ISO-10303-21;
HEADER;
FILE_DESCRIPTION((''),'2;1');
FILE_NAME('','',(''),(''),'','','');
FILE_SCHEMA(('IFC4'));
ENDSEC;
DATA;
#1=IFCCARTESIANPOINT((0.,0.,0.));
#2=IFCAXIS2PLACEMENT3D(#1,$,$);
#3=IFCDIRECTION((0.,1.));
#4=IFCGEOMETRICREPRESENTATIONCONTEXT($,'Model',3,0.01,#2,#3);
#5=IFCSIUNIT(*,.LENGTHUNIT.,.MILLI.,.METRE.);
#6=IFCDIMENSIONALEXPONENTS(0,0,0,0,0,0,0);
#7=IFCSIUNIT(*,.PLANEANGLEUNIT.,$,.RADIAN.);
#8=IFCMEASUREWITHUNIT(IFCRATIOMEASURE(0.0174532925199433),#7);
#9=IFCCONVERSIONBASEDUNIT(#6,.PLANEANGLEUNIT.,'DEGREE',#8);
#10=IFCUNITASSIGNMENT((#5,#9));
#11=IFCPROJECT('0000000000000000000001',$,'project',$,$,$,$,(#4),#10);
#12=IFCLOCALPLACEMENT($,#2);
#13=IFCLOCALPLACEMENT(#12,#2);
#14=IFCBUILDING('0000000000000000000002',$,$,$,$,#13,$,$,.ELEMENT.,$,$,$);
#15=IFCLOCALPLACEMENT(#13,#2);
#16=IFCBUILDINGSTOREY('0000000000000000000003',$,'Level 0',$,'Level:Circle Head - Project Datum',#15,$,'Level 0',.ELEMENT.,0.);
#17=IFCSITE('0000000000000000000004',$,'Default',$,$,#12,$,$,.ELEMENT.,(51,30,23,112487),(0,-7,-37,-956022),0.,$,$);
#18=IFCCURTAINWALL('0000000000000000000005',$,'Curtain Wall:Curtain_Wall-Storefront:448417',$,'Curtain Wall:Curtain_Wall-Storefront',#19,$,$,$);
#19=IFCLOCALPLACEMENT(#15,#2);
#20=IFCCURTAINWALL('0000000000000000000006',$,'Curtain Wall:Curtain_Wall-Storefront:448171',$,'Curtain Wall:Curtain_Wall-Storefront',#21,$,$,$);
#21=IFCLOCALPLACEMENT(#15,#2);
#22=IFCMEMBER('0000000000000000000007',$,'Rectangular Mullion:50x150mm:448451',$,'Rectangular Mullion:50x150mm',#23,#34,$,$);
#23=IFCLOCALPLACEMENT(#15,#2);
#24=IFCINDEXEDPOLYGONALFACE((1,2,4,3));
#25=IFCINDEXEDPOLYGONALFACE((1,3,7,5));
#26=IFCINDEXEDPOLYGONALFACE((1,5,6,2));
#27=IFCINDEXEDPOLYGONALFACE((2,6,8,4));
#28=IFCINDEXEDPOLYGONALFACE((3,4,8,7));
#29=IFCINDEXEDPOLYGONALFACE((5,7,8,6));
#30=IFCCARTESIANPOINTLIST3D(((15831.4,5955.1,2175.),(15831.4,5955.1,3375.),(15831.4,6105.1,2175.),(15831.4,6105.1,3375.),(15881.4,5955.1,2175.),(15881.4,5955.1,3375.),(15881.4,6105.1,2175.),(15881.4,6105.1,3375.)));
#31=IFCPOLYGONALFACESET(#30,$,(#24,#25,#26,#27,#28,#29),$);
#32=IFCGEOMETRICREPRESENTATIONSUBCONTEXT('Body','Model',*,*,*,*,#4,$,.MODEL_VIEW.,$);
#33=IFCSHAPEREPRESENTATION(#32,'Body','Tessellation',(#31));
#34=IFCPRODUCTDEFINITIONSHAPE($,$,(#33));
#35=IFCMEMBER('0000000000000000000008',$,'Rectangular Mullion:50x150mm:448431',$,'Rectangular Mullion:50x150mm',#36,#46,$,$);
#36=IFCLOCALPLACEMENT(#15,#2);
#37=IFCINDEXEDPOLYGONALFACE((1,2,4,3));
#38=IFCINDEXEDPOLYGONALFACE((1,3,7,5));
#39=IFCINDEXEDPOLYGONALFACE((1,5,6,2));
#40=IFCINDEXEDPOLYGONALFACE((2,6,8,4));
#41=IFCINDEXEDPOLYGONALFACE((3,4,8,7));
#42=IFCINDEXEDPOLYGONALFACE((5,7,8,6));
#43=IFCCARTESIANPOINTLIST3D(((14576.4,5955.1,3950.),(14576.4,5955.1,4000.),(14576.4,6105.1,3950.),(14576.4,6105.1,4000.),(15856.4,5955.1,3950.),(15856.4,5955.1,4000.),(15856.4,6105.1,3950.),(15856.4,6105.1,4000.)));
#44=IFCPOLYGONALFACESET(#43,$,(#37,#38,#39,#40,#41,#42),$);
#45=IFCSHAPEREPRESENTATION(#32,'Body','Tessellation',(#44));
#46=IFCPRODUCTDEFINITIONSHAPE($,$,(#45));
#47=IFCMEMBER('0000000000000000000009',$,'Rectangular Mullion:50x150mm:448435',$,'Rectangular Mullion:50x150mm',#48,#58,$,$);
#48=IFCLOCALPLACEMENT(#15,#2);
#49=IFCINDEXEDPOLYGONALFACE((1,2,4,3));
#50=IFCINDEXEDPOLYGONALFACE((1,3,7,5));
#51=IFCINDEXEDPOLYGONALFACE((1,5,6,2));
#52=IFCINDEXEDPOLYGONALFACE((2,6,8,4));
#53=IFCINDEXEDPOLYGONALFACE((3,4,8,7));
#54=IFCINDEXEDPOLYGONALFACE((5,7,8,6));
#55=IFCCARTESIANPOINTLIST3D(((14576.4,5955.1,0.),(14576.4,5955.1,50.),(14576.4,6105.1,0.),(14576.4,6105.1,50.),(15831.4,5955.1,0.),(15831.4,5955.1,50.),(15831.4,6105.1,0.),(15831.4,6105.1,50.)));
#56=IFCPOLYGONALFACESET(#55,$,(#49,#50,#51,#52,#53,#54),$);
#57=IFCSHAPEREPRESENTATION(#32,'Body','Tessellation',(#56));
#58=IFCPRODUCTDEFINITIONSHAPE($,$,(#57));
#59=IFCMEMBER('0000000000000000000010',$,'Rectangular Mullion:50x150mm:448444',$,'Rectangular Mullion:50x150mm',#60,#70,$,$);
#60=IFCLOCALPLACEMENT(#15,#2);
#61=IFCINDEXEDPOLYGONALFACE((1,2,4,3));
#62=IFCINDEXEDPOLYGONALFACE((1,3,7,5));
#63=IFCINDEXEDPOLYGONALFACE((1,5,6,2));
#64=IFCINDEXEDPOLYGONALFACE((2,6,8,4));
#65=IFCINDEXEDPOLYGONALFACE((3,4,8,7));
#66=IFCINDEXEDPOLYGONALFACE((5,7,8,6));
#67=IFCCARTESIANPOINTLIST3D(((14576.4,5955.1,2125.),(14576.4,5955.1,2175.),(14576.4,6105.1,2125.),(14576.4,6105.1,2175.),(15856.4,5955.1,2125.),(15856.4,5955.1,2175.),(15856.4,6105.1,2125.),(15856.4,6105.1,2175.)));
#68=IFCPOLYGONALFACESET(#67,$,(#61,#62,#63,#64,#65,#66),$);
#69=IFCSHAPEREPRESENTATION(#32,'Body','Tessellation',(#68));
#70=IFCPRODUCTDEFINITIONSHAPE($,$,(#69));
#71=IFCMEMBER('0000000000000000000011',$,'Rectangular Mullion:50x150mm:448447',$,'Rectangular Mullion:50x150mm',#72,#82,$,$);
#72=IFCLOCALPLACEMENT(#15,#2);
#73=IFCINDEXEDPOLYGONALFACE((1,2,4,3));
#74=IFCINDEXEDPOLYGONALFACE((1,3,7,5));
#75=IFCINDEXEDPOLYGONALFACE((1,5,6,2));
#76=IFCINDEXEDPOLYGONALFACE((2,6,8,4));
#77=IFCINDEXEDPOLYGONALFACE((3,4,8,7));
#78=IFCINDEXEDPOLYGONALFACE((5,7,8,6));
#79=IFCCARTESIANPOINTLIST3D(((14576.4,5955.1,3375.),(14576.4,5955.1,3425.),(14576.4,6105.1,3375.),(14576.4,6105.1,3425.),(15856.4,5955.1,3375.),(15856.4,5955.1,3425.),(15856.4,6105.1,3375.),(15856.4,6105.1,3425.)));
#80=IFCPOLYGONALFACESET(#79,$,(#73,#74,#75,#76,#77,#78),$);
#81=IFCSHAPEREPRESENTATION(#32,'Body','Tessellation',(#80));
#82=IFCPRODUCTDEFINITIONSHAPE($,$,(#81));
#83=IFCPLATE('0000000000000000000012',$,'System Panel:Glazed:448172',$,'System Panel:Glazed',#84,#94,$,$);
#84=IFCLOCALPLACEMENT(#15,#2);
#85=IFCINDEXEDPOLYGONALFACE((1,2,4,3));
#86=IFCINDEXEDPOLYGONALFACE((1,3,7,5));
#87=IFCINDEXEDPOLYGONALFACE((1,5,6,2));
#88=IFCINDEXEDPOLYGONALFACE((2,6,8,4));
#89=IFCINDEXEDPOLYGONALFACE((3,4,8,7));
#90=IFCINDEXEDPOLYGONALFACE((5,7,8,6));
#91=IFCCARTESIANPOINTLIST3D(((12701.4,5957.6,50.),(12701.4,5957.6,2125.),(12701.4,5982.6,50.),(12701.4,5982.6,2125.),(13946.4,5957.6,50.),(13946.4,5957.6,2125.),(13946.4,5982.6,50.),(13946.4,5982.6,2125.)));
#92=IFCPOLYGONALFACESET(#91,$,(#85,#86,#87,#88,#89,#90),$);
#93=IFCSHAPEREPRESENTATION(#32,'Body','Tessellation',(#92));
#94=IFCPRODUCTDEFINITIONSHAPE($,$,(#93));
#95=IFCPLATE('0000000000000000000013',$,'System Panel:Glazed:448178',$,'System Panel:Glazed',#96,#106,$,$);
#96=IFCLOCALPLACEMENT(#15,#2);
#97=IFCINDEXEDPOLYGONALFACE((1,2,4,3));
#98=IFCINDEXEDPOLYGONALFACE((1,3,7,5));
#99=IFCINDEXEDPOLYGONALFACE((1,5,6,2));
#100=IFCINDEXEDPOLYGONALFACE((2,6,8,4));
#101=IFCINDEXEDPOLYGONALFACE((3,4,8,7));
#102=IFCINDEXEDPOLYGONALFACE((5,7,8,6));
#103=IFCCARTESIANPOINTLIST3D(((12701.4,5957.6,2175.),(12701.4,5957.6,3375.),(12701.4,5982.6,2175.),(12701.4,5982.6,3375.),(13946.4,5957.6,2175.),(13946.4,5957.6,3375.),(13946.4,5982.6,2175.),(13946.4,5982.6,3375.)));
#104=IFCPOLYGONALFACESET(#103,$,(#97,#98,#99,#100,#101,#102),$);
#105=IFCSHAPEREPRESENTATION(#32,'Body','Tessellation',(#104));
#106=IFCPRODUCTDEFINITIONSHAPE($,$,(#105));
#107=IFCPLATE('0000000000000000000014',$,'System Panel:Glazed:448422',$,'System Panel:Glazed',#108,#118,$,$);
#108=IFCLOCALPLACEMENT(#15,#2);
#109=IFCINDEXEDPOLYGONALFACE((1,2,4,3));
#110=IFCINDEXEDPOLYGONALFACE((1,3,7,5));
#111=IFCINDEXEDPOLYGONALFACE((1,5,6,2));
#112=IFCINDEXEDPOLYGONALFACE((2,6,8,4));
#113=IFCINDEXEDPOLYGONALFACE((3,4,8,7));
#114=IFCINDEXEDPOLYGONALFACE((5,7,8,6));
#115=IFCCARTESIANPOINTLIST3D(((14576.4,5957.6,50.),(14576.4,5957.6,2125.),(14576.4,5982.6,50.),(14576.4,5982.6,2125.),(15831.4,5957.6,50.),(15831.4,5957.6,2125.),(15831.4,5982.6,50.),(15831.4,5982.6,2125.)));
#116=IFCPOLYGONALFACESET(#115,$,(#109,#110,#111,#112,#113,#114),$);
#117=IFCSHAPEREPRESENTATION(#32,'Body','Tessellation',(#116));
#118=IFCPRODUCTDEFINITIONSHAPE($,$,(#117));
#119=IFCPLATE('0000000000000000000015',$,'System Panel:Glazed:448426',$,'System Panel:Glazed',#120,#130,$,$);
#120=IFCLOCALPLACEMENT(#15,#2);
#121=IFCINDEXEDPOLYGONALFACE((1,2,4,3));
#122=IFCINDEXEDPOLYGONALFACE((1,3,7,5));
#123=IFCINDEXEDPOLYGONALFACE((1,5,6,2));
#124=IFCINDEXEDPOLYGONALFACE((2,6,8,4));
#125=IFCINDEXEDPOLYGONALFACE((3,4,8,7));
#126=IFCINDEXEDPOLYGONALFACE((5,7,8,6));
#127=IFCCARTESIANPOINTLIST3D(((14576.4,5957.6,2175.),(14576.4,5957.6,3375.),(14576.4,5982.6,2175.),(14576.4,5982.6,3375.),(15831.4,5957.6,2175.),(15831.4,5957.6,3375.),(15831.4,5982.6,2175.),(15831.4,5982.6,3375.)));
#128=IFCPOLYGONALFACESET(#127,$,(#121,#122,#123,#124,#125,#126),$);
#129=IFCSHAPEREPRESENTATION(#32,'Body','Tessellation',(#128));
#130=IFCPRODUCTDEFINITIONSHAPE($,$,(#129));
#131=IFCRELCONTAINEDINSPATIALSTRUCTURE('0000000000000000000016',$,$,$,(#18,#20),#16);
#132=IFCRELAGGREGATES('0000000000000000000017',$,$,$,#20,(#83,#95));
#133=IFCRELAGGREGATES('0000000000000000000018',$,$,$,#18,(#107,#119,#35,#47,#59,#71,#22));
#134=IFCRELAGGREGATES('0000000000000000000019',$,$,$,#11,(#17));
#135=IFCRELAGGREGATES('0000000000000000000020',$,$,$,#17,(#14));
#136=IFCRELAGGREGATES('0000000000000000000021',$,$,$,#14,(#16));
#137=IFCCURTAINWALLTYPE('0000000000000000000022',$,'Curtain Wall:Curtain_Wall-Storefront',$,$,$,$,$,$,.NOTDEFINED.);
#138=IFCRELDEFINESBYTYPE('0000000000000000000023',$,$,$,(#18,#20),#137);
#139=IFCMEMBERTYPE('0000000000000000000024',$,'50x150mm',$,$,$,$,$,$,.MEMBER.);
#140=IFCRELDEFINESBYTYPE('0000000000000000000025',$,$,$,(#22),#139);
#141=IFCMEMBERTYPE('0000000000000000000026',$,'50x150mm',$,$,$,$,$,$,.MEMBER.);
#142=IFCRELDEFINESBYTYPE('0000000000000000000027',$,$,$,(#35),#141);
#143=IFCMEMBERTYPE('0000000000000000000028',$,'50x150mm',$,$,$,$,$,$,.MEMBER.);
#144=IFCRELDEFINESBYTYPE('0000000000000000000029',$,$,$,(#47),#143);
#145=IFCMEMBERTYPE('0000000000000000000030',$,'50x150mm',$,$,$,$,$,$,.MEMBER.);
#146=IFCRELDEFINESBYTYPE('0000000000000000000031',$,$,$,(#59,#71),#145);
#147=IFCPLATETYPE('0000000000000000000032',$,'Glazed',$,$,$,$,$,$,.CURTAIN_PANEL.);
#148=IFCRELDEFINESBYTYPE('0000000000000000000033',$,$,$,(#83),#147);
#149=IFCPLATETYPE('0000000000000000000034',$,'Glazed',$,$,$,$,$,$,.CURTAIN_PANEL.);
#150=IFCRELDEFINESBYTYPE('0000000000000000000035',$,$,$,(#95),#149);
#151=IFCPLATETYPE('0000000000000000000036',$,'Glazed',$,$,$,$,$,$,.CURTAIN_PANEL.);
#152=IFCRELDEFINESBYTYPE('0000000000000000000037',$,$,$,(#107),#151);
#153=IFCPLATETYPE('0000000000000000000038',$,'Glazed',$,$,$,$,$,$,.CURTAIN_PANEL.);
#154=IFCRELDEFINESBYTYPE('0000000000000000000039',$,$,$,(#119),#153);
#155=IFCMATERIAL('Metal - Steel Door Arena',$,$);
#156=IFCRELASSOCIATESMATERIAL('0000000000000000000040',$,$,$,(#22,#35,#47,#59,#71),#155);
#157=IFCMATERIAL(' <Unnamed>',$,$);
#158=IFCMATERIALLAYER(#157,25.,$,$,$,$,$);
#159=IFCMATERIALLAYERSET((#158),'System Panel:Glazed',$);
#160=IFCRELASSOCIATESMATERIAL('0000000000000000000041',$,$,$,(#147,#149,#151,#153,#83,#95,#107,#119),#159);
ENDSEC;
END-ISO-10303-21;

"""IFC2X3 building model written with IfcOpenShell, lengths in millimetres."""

from ifc_helpers import new_model, entity, si_unit, converted_unit, direction, frame, origin, origin_2d_with_axis, place, context, subcontext, project, spatial, rectangle, extrude, source, transform, mapped, material, layer, layer_set, layer_usage, type_object, type_shapes, element, aggregate, save


model = new_model("IFC2X3")

# Units and contexts
model_context = context("Model", 3, precision=0.01, world=origin(), true_north=direction((0.0, 1.0)))
body_context = subcontext(model_context, "Body", "Model", "MODEL_VIEW")
ifc_project = project(units=[si_unit("LENGTHUNIT", "METRE", prefix="MILLI"), converted_unit("PLANEANGLEUNIT", "DEGREE", entity("IfcRatioMeasure", 0.0174532925199433), si_unit("PLANEANGLEUNIT", "RADIAN"), dimensions=[0, 0, 0, 0, 0, 0, 0])], contexts=[model_context])

# Site, building, storey
site_placement = place(None, origin())
site = spatial("IfcSite", under=ifc_project, at=site_placement, Name="Default", CompositionType="ELEMENT", RefLatitude=(51, 30, 23, 112487), RefLongitude=(0, -7, -37, -956022), RefElevation=0.0)
building_placement = place(site_placement, origin())
building = spatial("IfcBuilding", under=site, at=building_placement, CompositionType="ELEMENT")
storey_placement = place(building_placement, origin())
storey = spatial("IfcBuildingStorey", under=building, at=storey_placement, Name="Level 0", ObjectType="Level:Circle Head - Project Datum", LongName="Level 0", CompositionType="ELEMENT", Elevation=0.0)

# Curtain walls
curtain_wall_type = type_object("IfcCurtainWallType", Name="Curtain Wall:Curtain_Wall-Storefront", PredefinedType="NOTDEFINED")
curtain_wall_1_placement = place(storey_placement, origin())
curtain_wall_1 = element("IfcCurtainWall", 1, at=curtain_wall_1_placement, inside=storey, type_object=curtain_wall_type, Name="Curtain Wall:Curtain_Wall-Storefront:448417", ObjectType="Curtain Wall:Curtain_Wall-Storefront")
ifc_material_1 = material(Name="Metal - Steel Door Arena")
curtain_wall_2_placement = place(storey_placement, origin())
curtain_wall_2 = element("IfcCurtainWall", 2, at=curtain_wall_2_placement, inside=storey, type_object=curtain_wall_type, Name="Curtain Wall:Curtain_Wall-Storefront:448171", ObjectType="Curtain Wall:Curtain_Wall-Storefront")

# Members
member_type_1 = type_object("IfcMemberType", Name="50x150mm", PredefinedType="MEMBER")
shared_shape_1 = source(origin(), body_context, "Body", "SweptSolid", [
    extrude(rectangle(XDim=150.0, YDim=50.0, at=origin_2d_with_axis()), frame((0.0, 0.0, -1200.0), z_axis=(0.0, 0.0, 1.0), x_axis=(0.0, -1.0, 0.0)), (0.0, 0.0, 1.0), 1200.0),
])
type_shapes(member_type_1, [shared_shape_1])
member_1_placement = place(storey_placement, frame((15856.4, 6030.1, 2175.0), z_axis=(0.0, 0.0, -1.0), x_axis=(-1.0, 0.0, 0.0)))
member_1 = element("IfcMember", 3, at=member_1_placement, type_object=member_type_1, material=ifc_material_1, Name="Rectangular Mullion:50x150mm:448451", ObjectType="Rectangular Mullion:50x150mm", context=body_context, shape_type="MappedRepresentation", body=[
    mapped(shared_shape_1, transform((0.0, 0.0, 0.0), scale=1.0)),
])
member_type_2 = type_object("IfcMemberType", Name="50x150mm", PredefinedType="MEMBER")
shared_shape_2 = source(origin(), body_context, "Body", "SweptSolid", [
    extrude(rectangle(XDim=150.0, YDim=50.0, at=origin_2d_with_axis()), frame((-25.0, 0.0, -1280.0), z_axis=(0.0, 0.0, 1.0), x_axis=(0.0, -1.0, 0.0)), (0.0, 0.0, 1.0), 1280.0),
])
type_shapes(member_type_2, [shared_shape_2])
member_2_placement = place(storey_placement, frame((14576.4, 6030.1, 4000.0), z_axis=(-1.0, 0.0, 0.0), x_axis=(0.0, 0.0, 1.0)))
member_2 = element("IfcMember", 4, at=member_2_placement, type_object=member_type_2, material=ifc_material_1, Name="Rectangular Mullion:50x150mm:448431", ObjectType="Rectangular Mullion:50x150mm", context=body_context, shape_type="MappedRepresentation", body=[
    mapped(shared_shape_2, transform((0.0, 0.0, 0.0), scale=1.0)),
])
member_type_3 = type_object("IfcMemberType", Name="50x150mm", PredefinedType="MEMBER")
shared_shape_3 = source(origin(), body_context, "Body", "SweptSolid", [
    extrude(rectangle(XDim=150.0, YDim=50.0, at=origin_2d_with_axis()), frame((-25.0, 0.0, -1255.0), z_axis=(0.0, 0.0, 1.0), x_axis=(0.0, -1.0, 0.0)), (0.0, 0.0, 1.0), 1255.0),
])
type_shapes(member_type_3, [shared_shape_3])
member_3_placement = place(storey_placement, frame((15831.4, 6030.1, 0.0), z_axis=(1.0, 0.0, 0.0), x_axis=(0.0, 0.0, -1.0)))
member_3 = element("IfcMember", 5, at=member_3_placement, type_object=member_type_3, material=ifc_material_1, Name="Rectangular Mullion:50x150mm:448435", ObjectType="Rectangular Mullion:50x150mm", context=body_context, shape_type="MappedRepresentation", body=[
    mapped(shared_shape_3, transform((0.0, 0.0, 0.0), scale=1.0)),
])
member_type_4 = type_object("IfcMemberType", Name="50x150mm", PredefinedType="MEMBER")
shared_shape_4 = source(origin(), body_context, "Body", "SweptSolid", [
    extrude(rectangle(XDim=150.0, YDim=50.0, at=origin_2d_with_axis()), frame((0.0, 0.0, -1280.0), z_axis=(0.0, 0.0, 1.0), x_axis=(0.0, -1.0, 0.0)), (0.0, 0.0, 1.0), 1280.0),
])
type_shapes(member_type_4, [shared_shape_4])
member_4_placement = place(storey_placement, frame((14576.4, 6030.1, 2150.0), z_axis=(-1.0, 0.0, 0.0), x_axis=(0.0, 0.0, 1.0)))
member_4 = element("IfcMember", 6, at=member_4_placement, type_object=member_type_4, material=ifc_material_1, Name="Rectangular Mullion:50x150mm:448444", ObjectType="Rectangular Mullion:50x150mm", context=body_context, shape_type="MappedRepresentation", body=[
    mapped(shared_shape_4, transform((0.0, 0.0, 0.0), scale=1.0)),
])
member_5_placement = place(storey_placement, frame((14576.4, 6030.1, 3400.0), z_axis=(-1.0, 0.0, 0.0), x_axis=(0.0, 0.0, 1.0)))
member_5 = element("IfcMember", 7, at=member_5_placement, type_object=member_type_4, material=ifc_material_1, Name="Rectangular Mullion:50x150mm:448447", ObjectType="Rectangular Mullion:50x150mm", context=body_context, shape_type="MappedRepresentation", body=[
    mapped(shared_shape_4, transform((0.0, 0.0, 0.0), scale=1.0)),
])

# Plates
ifc_material_2 = material(Name=" <Unnamed>")
ifc_layer = layer(ifc_material_2, 25.0)
ifc_layer_set = layer_set([ifc_layer], Name="System Panel:Glazed")
ifc_layer_usage_1 = layer_usage(ifc_layer_set, "AXIS3", "POSITIVE", 0.2)
plate_type_1 = type_object("IfcPlateType", Name="Glazed", PredefinedType="CURTAIN_PANEL", material=ifc_layer_set)
shared_shape_5 = source(origin(), body_context, "Body", "SweptSolid", [
    extrude(rectangle(XDim=25.0, YDim=1245.0, at=origin_2d_with_axis()), frame((0.0, 60.0, 0.0), z_axis=(0.0, 0.0, 1.0), x_axis=(0.0, 1.0, 0.0)), (0.0, 0.0, 1.0), 2075.0),
])
type_shapes(plate_type_1, [shared_shape_5])
plate_1_placement = place(curtain_wall_2_placement, frame((13323.9, 6030.1, 50.0), z_axis=(0.0, 0.0, 1.0), x_axis=(-1.0, 0.0, 0.0)))
plate_1 = element("IfcPlate", 8, at=plate_1_placement, type_object=plate_type_1, material=ifc_layer_usage_1, Name="System Panel:Glazed:448172", ObjectType="System Panel:Glazed", context=body_context, shape_type="MappedRepresentation", body=[
    mapped(shared_shape_5, transform((0.0, 0.0, 0.0), scale=1.0)),
])
ifc_layer_usage_2 = layer_usage(ifc_layer_set, "AXIS3", "POSITIVE", 0.2)
plate_type_2 = type_object("IfcPlateType", Name="Glazed", PredefinedType="CURTAIN_PANEL", material=ifc_layer_set)
shared_shape_6 = source(origin(), body_context, "Body", "SweptSolid", [
    extrude(rectangle(XDim=25.0, YDim=1245.0, at=origin_2d_with_axis()), frame((0.0, 60.0, 0.0), z_axis=(0.0, 0.0, 1.0), x_axis=(0.0, 1.0, 0.0)), (0.0, 0.0, 1.0), 1200.0),
])
type_shapes(plate_type_2, [shared_shape_6])
plate_2_placement = place(curtain_wall_2_placement, frame((13323.9, 6030.1, 2175.0), z_axis=(0.0, 0.0, 1.0), x_axis=(-1.0, 0.0, 0.0)))
plate_2 = element("IfcPlate", 9, at=plate_2_placement, type_object=plate_type_2, material=ifc_layer_usage_2, Name="System Panel:Glazed:448178", ObjectType="System Panel:Glazed", context=body_context, shape_type="MappedRepresentation", body=[
    mapped(shared_shape_6, transform((0.0, 0.0, 0.0), scale=1.0)),
])
aggregate(curtain_wall_2, [plate_1, plate_2])
ifc_layer_usage_3 = layer_usage(ifc_layer_set, "AXIS3", "POSITIVE", 0.2)
plate_type_3 = type_object("IfcPlateType", Name="Glazed", PredefinedType="CURTAIN_PANEL", material=ifc_layer_set)
shared_shape_7 = source(origin(), body_context, "Body", "SweptSolid", [
    extrude(rectangle(XDim=25.0, YDim=1255.0, at=origin_2d_with_axis()), frame((0.0, 60.0, 0.0), z_axis=(0.0, 0.0, 1.0), x_axis=(0.0, 1.0, 0.0)), (0.0, 0.0, 1.0), 2075.0),
])
type_shapes(plate_type_3, [shared_shape_7])
plate_3_placement = place(curtain_wall_1_placement, frame((15203.9, 6030.1, 50.0), z_axis=(0.0, 0.0, 1.0), x_axis=(-1.0, 0.0, 0.0)))
plate_3 = element("IfcPlate", 10, at=plate_3_placement, type_object=plate_type_3, material=ifc_layer_usage_3, Name="System Panel:Glazed:448422", ObjectType="System Panel:Glazed", context=body_context, shape_type="MappedRepresentation", body=[
    mapped(shared_shape_7, transform((0.0, 0.0, 0.0), scale=1.0)),
])
ifc_layer_usage_4 = layer_usage(ifc_layer_set, "AXIS3", "POSITIVE", 0.2)
plate_type_4 = type_object("IfcPlateType", Name="Glazed", PredefinedType="CURTAIN_PANEL", material=ifc_layer_set)
shared_shape_8 = source(origin(), body_context, "Body", "SweptSolid", [
    extrude(rectangle(XDim=25.0, YDim=1255.0, at=origin_2d_with_axis()), frame((0.0, 60.0, 0.0), z_axis=(0.0, 0.0, 1.0), x_axis=(0.0, 1.0, 0.0)), (0.0, 0.0, 1.0), 1200.0),
])
type_shapes(plate_type_4, [shared_shape_8])
plate_4_placement = place(curtain_wall_1_placement, frame((15203.9, 6030.1, 2175.0), z_axis=(0.0, 0.0, 1.0), x_axis=(-1.0, 0.0, 0.0)))
plate_4 = element("IfcPlate", 11, at=plate_4_placement, type_object=plate_type_4, material=ifc_layer_usage_4, Name="System Panel:Glazed:448426", ObjectType="System Panel:Glazed", context=body_context, shape_type="MappedRepresentation", body=[
    mapped(shared_shape_8, transform((0.0, 0.0, 0.0), scale=1.0)),
])
aggregate(curtain_wall_1, [plate_3, plate_4, member_2, member_3, member_4, member_5, member_1])

save(model, "model.ifc")
